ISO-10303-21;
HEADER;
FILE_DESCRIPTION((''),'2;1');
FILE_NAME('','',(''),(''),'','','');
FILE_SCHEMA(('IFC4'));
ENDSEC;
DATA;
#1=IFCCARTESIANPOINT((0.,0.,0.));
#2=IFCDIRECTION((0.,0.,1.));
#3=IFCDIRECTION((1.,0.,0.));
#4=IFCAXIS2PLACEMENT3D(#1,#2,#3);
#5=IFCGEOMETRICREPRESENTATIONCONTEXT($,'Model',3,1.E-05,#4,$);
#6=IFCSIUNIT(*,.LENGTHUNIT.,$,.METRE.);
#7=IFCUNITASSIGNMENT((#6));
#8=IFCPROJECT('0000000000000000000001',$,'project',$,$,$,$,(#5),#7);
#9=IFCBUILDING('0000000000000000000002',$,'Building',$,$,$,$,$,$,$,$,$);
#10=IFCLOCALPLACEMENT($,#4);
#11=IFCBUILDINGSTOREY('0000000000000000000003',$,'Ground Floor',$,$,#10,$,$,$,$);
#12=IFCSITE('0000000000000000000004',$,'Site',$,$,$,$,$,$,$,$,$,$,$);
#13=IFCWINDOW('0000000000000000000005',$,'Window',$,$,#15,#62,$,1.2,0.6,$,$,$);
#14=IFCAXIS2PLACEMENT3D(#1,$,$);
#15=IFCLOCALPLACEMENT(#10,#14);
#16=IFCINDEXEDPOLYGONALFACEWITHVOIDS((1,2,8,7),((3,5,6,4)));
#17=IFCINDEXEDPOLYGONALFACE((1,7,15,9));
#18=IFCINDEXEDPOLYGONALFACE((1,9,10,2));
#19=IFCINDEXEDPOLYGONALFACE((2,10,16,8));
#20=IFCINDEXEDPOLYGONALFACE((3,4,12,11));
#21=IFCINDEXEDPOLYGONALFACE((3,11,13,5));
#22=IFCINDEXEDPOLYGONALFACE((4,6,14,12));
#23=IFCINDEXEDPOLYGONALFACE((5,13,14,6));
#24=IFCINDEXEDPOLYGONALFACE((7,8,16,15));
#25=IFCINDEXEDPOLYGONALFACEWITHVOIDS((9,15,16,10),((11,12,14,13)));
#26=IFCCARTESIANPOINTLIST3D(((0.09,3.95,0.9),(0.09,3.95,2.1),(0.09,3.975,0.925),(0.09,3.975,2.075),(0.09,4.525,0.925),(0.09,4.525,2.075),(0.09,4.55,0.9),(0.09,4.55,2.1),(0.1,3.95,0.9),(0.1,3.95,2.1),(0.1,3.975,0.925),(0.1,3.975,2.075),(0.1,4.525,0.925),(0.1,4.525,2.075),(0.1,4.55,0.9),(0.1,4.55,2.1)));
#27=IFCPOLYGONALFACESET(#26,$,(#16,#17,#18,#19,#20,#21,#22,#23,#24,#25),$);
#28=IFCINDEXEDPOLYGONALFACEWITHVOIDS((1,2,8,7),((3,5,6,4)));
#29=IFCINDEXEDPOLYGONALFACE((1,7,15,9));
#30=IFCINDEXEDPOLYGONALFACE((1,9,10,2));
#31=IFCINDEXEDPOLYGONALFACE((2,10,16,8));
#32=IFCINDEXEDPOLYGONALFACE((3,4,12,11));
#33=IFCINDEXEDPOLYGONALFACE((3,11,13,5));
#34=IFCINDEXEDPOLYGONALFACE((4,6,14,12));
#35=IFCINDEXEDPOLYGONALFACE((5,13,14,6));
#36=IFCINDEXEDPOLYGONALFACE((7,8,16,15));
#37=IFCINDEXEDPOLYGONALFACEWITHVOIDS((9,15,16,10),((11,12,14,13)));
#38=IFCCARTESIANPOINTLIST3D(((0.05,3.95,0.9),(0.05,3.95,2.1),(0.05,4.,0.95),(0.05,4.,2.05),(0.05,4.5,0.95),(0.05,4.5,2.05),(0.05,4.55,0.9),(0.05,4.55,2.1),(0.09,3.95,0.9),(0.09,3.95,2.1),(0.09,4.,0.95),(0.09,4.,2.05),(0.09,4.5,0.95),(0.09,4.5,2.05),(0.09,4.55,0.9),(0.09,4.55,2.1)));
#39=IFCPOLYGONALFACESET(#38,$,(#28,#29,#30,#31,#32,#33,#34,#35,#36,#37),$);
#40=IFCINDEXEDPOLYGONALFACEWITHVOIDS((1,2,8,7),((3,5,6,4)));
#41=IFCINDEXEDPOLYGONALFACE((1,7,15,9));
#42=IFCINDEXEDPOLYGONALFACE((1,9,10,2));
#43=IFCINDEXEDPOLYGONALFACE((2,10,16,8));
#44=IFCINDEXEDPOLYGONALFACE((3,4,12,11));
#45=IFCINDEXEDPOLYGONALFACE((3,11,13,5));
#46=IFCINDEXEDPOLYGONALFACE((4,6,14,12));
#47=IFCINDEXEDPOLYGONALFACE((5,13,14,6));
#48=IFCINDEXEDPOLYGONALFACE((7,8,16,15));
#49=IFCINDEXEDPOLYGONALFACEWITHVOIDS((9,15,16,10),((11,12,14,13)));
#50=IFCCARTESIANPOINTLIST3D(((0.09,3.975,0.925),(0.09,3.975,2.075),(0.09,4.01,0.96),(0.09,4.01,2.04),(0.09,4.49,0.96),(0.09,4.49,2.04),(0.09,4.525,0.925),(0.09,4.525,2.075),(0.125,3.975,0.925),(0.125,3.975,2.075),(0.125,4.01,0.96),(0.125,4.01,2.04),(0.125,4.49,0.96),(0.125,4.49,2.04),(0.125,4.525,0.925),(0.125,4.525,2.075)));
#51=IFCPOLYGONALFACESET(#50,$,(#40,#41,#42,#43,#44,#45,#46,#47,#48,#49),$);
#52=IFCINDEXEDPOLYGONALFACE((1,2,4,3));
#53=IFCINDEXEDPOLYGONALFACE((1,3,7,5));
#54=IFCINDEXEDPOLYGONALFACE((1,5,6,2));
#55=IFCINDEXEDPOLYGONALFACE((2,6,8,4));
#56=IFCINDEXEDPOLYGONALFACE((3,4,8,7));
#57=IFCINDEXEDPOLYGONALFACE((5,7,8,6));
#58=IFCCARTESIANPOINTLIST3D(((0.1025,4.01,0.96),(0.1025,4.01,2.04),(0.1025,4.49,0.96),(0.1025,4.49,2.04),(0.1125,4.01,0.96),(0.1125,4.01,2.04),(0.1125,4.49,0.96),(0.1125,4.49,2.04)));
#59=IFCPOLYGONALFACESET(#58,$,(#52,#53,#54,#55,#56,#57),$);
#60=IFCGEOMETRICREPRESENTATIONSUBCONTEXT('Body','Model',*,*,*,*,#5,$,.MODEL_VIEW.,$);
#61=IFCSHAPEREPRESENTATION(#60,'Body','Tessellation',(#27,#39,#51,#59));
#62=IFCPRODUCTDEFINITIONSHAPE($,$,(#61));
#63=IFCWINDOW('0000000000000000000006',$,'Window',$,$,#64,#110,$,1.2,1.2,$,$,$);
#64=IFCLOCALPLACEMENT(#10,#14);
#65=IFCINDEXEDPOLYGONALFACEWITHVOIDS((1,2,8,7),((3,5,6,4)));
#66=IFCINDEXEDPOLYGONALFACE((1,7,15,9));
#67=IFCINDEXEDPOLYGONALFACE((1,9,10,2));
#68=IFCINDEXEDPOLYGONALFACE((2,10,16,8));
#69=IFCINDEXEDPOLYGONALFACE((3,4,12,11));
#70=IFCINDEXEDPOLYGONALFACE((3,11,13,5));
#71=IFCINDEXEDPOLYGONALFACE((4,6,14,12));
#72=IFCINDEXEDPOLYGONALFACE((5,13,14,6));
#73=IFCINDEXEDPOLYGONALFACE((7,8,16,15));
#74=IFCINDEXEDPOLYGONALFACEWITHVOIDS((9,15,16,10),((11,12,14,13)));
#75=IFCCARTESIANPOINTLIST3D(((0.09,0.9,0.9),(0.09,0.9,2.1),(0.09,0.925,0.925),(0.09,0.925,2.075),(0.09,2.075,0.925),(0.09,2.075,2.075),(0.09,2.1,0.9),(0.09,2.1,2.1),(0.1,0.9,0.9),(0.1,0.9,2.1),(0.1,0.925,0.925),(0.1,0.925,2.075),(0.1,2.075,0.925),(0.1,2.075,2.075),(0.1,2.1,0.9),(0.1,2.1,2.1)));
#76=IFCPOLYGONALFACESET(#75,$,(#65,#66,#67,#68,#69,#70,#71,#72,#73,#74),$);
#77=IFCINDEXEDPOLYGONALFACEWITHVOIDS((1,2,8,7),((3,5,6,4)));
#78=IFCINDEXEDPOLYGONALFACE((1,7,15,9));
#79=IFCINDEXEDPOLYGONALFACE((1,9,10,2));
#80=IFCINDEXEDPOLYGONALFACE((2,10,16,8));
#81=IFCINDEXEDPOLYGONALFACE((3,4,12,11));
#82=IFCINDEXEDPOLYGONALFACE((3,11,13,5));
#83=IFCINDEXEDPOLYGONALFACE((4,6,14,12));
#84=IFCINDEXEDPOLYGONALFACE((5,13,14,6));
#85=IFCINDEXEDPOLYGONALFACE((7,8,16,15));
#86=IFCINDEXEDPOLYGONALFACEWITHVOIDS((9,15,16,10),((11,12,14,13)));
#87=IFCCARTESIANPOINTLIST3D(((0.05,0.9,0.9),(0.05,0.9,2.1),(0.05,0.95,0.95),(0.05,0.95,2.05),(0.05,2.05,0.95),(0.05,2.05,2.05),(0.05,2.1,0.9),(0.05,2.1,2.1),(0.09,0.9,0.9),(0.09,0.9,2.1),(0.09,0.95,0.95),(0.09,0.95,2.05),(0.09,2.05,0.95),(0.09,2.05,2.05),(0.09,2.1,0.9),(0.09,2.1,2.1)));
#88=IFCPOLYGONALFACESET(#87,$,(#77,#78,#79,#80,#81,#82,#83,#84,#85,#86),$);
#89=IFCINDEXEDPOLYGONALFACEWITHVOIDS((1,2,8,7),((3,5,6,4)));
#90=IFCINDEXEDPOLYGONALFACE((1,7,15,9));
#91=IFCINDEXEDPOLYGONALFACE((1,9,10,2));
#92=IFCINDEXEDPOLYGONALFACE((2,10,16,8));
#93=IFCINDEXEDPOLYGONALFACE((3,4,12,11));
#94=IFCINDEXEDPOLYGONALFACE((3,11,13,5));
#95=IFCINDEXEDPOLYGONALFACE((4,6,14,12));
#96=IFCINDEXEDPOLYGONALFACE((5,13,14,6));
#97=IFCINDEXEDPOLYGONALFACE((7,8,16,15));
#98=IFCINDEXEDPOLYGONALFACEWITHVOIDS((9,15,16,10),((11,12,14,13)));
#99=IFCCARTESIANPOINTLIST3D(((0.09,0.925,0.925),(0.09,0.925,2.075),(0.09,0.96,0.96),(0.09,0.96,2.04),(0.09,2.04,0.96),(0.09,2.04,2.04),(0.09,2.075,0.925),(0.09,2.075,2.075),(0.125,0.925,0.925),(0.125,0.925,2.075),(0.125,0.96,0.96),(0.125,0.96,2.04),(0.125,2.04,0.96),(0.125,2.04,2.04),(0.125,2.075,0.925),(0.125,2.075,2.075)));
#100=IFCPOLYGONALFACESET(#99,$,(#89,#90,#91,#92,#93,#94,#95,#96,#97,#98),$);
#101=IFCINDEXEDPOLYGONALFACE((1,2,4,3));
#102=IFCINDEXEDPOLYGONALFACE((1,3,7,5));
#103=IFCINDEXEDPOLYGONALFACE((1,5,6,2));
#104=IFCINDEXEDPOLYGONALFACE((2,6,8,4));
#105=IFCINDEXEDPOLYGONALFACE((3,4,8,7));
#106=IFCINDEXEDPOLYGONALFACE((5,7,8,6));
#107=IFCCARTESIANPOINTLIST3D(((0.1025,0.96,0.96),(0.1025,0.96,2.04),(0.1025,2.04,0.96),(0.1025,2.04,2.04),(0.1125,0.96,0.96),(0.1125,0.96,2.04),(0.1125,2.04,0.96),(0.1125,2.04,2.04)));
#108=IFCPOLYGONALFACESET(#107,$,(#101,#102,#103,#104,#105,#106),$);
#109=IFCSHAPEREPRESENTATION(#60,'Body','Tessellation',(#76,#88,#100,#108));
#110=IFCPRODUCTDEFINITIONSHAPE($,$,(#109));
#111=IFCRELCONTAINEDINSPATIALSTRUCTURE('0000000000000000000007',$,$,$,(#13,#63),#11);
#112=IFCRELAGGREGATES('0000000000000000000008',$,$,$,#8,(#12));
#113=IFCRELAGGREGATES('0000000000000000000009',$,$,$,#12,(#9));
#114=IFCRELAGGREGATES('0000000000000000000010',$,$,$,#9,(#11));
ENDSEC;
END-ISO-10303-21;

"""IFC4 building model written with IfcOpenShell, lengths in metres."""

from ifc_helpers import new_model, si_unit, frame, origin_with_axes, place, context, subcontext, project, spatial, line, indexed_curve, outline, extrude, element, save


model = new_model("IFC4")

# Units and contexts
model_context = context("Model", 3, precision=1e-05, world=origin_with_axes())
body_context = subcontext(model_context, "Body", "Model", "MODEL_VIEW")
ifc_project = project(units=[si_unit("LENGTHUNIT", "METRE")], contexts=[model_context])

# Site, building, storey
site = spatial("IfcSite", under=ifc_project, Name="Site")
building = spatial("IfcBuilding", under=site, Name="Building")
storey_placement = place(None, origin_with_axes())
storey = spatial("IfcBuildingStorey", under=building, at=storey_placement, Name="Ground Floor")

# Windows
window_1_placement = place(storey_placement, frame((0.0, 4.55, 0.9), z_axis=(0.0, 0.0, 1.0), x_axis=(0.0, -1.0, 0.0)))
element("IfcWindow", 1, at=window_1_placement, inside=storey, Name="Window", OverallHeight=1.2, OverallWidth=0.6, context=body_context, shape_type="SweptSolid", body=[
    extrude(outline(indexed_curve([(0.0, 0.0), (0.6, 0.0), (0.6, 1.2), (0.0, 1.2)], segments=[line(1, 2, 3, 4, 1)]), holes=[indexed_curve([(0.025, 0.025), (0.575, 0.025), (0.575, 1.175), (0.025, 1.175)], segments=[line(1, 2, 3, 4, 1)])]), frame((0.0, 0.09, 0.0), z_axis=(0.0, -1.0, 0.0), x_axis=(1.0, 0.0, 0.0)), (0.0, 0.0, -1.0), 0.01),
    extrude(outline(indexed_curve([(0.0, 0.0), (0.6, 0.0), (0.6, 1.2), (0.0, 1.2)], segments=[line(1, 2, 3, 4, 1)]), holes=[indexed_curve([(0.05, 0.05), (0.55, 0.05), (0.55, 1.15), (0.05, 1.15)], segments=[line(1, 2, 3, 4, 1)])]), frame((0.0, 0.05, 0.0), z_axis=(0.0, -1.0, 0.0), x_axis=(1.0, 0.0, 0.0)), (0.0, 0.0, -1.0), 0.04),
    extrude(outline(indexed_curve([(0.0, 0.0), (0.55, 0.0), (0.55, 1.15), (0.0, 1.15)], segments=[line(1, 2, 3, 4, 1)]), holes=[indexed_curve([(0.035, 0.035), (0.515, 0.035), (0.515, 1.115), (0.035, 1.115)], segments=[line(1, 2, 3, 4, 1)])]), frame((0.025, 0.09, 0.025), z_axis=(0.0, -1.0, 0.0), x_axis=(1.0, 0.0, 0.0)), (0.0, 0.0, -1.0), 0.035),
    extrude(outline(indexed_curve([(0.035, 0.035), (0.515, 0.035), (0.515, 1.115), (0.035, 1.115)], segments=[line(1, 2, 3, 4, 1)])), frame((0.025, 0.1025, 0.025), z_axis=(0.0, -1.0, 0.0), x_axis=(1.0, 0.0, 0.0)), (0.0, 0.0, -1.0), 0.01),
])
window_2_placement = place(storey_placement, frame((0.0, 2.1, 0.9), z_axis=(0.0, 0.0, 1.0), x_axis=(0.0, -1.0, 0.0)))
element("IfcWindow", 2, at=window_2_placement, inside=storey, Name="Window", OverallHeight=1.2, OverallWidth=1.2, context=body_context, shape_type="SweptSolid", body=[
    extrude(outline(indexed_curve([(0.0, 0.0), (1.2, 0.0), (1.2, 1.2), (0.0, 1.2)], segments=[line(1, 2, 3, 4, 1)]), holes=[indexed_curve([(0.025, 0.025), (1.175, 0.025), (1.175, 1.175), (0.025, 1.175)], segments=[line(1, 2, 3, 4, 1)])]), frame((0.0, 0.09, 0.0), z_axis=(0.0, -1.0, 0.0), x_axis=(1.0, 0.0, 0.0)), (0.0, 0.0, -1.0), 0.01),
    extrude(outline(indexed_curve([(0.0, 0.0), (1.2, 0.0), (1.2, 1.2), (0.0, 1.2)], segments=[line(1, 2, 3, 4, 1)]), holes=[indexed_curve([(0.05, 0.05), (1.15, 0.05), (1.15, 1.15), (0.05, 1.15)], segments=[line(1, 2, 3, 4, 1)])]), frame((0.0, 0.05, 0.0), z_axis=(0.0, -1.0, 0.0), x_axis=(1.0, 0.0, 0.0)), (0.0, 0.0, -1.0), 0.04),
    extrude(outline(indexed_curve([(0.0, 0.0), (1.15, 0.0), (1.15, 1.15), (0.0, 1.15)], segments=[line(1, 2, 3, 4, 1)]), holes=[indexed_curve([(0.035, 0.035), (1.115, 0.035), (1.115, 1.115), (0.035, 1.115)], segments=[line(1, 2, 3, 4, 1)])]), frame((0.025, 0.09, 0.025), z_axis=(0.0, -1.0, 0.0), x_axis=(1.0, 0.0, 0.0)), (0.0, 0.0, -1.0), 0.035),
    extrude(outline(indexed_curve([(0.035, 0.035), (1.115, 0.035), (1.115, 1.115), (0.035, 1.115)], segments=[line(1, 2, 3, 4, 1)])), frame((0.025, 0.1025, 0.025), z_axis=(0.0, -1.0, 0.0), x_axis=(1.0, 0.0, 0.0)), (0.0, 0.0, -1.0), 0.01),
])

save(model, "model.ifc")
